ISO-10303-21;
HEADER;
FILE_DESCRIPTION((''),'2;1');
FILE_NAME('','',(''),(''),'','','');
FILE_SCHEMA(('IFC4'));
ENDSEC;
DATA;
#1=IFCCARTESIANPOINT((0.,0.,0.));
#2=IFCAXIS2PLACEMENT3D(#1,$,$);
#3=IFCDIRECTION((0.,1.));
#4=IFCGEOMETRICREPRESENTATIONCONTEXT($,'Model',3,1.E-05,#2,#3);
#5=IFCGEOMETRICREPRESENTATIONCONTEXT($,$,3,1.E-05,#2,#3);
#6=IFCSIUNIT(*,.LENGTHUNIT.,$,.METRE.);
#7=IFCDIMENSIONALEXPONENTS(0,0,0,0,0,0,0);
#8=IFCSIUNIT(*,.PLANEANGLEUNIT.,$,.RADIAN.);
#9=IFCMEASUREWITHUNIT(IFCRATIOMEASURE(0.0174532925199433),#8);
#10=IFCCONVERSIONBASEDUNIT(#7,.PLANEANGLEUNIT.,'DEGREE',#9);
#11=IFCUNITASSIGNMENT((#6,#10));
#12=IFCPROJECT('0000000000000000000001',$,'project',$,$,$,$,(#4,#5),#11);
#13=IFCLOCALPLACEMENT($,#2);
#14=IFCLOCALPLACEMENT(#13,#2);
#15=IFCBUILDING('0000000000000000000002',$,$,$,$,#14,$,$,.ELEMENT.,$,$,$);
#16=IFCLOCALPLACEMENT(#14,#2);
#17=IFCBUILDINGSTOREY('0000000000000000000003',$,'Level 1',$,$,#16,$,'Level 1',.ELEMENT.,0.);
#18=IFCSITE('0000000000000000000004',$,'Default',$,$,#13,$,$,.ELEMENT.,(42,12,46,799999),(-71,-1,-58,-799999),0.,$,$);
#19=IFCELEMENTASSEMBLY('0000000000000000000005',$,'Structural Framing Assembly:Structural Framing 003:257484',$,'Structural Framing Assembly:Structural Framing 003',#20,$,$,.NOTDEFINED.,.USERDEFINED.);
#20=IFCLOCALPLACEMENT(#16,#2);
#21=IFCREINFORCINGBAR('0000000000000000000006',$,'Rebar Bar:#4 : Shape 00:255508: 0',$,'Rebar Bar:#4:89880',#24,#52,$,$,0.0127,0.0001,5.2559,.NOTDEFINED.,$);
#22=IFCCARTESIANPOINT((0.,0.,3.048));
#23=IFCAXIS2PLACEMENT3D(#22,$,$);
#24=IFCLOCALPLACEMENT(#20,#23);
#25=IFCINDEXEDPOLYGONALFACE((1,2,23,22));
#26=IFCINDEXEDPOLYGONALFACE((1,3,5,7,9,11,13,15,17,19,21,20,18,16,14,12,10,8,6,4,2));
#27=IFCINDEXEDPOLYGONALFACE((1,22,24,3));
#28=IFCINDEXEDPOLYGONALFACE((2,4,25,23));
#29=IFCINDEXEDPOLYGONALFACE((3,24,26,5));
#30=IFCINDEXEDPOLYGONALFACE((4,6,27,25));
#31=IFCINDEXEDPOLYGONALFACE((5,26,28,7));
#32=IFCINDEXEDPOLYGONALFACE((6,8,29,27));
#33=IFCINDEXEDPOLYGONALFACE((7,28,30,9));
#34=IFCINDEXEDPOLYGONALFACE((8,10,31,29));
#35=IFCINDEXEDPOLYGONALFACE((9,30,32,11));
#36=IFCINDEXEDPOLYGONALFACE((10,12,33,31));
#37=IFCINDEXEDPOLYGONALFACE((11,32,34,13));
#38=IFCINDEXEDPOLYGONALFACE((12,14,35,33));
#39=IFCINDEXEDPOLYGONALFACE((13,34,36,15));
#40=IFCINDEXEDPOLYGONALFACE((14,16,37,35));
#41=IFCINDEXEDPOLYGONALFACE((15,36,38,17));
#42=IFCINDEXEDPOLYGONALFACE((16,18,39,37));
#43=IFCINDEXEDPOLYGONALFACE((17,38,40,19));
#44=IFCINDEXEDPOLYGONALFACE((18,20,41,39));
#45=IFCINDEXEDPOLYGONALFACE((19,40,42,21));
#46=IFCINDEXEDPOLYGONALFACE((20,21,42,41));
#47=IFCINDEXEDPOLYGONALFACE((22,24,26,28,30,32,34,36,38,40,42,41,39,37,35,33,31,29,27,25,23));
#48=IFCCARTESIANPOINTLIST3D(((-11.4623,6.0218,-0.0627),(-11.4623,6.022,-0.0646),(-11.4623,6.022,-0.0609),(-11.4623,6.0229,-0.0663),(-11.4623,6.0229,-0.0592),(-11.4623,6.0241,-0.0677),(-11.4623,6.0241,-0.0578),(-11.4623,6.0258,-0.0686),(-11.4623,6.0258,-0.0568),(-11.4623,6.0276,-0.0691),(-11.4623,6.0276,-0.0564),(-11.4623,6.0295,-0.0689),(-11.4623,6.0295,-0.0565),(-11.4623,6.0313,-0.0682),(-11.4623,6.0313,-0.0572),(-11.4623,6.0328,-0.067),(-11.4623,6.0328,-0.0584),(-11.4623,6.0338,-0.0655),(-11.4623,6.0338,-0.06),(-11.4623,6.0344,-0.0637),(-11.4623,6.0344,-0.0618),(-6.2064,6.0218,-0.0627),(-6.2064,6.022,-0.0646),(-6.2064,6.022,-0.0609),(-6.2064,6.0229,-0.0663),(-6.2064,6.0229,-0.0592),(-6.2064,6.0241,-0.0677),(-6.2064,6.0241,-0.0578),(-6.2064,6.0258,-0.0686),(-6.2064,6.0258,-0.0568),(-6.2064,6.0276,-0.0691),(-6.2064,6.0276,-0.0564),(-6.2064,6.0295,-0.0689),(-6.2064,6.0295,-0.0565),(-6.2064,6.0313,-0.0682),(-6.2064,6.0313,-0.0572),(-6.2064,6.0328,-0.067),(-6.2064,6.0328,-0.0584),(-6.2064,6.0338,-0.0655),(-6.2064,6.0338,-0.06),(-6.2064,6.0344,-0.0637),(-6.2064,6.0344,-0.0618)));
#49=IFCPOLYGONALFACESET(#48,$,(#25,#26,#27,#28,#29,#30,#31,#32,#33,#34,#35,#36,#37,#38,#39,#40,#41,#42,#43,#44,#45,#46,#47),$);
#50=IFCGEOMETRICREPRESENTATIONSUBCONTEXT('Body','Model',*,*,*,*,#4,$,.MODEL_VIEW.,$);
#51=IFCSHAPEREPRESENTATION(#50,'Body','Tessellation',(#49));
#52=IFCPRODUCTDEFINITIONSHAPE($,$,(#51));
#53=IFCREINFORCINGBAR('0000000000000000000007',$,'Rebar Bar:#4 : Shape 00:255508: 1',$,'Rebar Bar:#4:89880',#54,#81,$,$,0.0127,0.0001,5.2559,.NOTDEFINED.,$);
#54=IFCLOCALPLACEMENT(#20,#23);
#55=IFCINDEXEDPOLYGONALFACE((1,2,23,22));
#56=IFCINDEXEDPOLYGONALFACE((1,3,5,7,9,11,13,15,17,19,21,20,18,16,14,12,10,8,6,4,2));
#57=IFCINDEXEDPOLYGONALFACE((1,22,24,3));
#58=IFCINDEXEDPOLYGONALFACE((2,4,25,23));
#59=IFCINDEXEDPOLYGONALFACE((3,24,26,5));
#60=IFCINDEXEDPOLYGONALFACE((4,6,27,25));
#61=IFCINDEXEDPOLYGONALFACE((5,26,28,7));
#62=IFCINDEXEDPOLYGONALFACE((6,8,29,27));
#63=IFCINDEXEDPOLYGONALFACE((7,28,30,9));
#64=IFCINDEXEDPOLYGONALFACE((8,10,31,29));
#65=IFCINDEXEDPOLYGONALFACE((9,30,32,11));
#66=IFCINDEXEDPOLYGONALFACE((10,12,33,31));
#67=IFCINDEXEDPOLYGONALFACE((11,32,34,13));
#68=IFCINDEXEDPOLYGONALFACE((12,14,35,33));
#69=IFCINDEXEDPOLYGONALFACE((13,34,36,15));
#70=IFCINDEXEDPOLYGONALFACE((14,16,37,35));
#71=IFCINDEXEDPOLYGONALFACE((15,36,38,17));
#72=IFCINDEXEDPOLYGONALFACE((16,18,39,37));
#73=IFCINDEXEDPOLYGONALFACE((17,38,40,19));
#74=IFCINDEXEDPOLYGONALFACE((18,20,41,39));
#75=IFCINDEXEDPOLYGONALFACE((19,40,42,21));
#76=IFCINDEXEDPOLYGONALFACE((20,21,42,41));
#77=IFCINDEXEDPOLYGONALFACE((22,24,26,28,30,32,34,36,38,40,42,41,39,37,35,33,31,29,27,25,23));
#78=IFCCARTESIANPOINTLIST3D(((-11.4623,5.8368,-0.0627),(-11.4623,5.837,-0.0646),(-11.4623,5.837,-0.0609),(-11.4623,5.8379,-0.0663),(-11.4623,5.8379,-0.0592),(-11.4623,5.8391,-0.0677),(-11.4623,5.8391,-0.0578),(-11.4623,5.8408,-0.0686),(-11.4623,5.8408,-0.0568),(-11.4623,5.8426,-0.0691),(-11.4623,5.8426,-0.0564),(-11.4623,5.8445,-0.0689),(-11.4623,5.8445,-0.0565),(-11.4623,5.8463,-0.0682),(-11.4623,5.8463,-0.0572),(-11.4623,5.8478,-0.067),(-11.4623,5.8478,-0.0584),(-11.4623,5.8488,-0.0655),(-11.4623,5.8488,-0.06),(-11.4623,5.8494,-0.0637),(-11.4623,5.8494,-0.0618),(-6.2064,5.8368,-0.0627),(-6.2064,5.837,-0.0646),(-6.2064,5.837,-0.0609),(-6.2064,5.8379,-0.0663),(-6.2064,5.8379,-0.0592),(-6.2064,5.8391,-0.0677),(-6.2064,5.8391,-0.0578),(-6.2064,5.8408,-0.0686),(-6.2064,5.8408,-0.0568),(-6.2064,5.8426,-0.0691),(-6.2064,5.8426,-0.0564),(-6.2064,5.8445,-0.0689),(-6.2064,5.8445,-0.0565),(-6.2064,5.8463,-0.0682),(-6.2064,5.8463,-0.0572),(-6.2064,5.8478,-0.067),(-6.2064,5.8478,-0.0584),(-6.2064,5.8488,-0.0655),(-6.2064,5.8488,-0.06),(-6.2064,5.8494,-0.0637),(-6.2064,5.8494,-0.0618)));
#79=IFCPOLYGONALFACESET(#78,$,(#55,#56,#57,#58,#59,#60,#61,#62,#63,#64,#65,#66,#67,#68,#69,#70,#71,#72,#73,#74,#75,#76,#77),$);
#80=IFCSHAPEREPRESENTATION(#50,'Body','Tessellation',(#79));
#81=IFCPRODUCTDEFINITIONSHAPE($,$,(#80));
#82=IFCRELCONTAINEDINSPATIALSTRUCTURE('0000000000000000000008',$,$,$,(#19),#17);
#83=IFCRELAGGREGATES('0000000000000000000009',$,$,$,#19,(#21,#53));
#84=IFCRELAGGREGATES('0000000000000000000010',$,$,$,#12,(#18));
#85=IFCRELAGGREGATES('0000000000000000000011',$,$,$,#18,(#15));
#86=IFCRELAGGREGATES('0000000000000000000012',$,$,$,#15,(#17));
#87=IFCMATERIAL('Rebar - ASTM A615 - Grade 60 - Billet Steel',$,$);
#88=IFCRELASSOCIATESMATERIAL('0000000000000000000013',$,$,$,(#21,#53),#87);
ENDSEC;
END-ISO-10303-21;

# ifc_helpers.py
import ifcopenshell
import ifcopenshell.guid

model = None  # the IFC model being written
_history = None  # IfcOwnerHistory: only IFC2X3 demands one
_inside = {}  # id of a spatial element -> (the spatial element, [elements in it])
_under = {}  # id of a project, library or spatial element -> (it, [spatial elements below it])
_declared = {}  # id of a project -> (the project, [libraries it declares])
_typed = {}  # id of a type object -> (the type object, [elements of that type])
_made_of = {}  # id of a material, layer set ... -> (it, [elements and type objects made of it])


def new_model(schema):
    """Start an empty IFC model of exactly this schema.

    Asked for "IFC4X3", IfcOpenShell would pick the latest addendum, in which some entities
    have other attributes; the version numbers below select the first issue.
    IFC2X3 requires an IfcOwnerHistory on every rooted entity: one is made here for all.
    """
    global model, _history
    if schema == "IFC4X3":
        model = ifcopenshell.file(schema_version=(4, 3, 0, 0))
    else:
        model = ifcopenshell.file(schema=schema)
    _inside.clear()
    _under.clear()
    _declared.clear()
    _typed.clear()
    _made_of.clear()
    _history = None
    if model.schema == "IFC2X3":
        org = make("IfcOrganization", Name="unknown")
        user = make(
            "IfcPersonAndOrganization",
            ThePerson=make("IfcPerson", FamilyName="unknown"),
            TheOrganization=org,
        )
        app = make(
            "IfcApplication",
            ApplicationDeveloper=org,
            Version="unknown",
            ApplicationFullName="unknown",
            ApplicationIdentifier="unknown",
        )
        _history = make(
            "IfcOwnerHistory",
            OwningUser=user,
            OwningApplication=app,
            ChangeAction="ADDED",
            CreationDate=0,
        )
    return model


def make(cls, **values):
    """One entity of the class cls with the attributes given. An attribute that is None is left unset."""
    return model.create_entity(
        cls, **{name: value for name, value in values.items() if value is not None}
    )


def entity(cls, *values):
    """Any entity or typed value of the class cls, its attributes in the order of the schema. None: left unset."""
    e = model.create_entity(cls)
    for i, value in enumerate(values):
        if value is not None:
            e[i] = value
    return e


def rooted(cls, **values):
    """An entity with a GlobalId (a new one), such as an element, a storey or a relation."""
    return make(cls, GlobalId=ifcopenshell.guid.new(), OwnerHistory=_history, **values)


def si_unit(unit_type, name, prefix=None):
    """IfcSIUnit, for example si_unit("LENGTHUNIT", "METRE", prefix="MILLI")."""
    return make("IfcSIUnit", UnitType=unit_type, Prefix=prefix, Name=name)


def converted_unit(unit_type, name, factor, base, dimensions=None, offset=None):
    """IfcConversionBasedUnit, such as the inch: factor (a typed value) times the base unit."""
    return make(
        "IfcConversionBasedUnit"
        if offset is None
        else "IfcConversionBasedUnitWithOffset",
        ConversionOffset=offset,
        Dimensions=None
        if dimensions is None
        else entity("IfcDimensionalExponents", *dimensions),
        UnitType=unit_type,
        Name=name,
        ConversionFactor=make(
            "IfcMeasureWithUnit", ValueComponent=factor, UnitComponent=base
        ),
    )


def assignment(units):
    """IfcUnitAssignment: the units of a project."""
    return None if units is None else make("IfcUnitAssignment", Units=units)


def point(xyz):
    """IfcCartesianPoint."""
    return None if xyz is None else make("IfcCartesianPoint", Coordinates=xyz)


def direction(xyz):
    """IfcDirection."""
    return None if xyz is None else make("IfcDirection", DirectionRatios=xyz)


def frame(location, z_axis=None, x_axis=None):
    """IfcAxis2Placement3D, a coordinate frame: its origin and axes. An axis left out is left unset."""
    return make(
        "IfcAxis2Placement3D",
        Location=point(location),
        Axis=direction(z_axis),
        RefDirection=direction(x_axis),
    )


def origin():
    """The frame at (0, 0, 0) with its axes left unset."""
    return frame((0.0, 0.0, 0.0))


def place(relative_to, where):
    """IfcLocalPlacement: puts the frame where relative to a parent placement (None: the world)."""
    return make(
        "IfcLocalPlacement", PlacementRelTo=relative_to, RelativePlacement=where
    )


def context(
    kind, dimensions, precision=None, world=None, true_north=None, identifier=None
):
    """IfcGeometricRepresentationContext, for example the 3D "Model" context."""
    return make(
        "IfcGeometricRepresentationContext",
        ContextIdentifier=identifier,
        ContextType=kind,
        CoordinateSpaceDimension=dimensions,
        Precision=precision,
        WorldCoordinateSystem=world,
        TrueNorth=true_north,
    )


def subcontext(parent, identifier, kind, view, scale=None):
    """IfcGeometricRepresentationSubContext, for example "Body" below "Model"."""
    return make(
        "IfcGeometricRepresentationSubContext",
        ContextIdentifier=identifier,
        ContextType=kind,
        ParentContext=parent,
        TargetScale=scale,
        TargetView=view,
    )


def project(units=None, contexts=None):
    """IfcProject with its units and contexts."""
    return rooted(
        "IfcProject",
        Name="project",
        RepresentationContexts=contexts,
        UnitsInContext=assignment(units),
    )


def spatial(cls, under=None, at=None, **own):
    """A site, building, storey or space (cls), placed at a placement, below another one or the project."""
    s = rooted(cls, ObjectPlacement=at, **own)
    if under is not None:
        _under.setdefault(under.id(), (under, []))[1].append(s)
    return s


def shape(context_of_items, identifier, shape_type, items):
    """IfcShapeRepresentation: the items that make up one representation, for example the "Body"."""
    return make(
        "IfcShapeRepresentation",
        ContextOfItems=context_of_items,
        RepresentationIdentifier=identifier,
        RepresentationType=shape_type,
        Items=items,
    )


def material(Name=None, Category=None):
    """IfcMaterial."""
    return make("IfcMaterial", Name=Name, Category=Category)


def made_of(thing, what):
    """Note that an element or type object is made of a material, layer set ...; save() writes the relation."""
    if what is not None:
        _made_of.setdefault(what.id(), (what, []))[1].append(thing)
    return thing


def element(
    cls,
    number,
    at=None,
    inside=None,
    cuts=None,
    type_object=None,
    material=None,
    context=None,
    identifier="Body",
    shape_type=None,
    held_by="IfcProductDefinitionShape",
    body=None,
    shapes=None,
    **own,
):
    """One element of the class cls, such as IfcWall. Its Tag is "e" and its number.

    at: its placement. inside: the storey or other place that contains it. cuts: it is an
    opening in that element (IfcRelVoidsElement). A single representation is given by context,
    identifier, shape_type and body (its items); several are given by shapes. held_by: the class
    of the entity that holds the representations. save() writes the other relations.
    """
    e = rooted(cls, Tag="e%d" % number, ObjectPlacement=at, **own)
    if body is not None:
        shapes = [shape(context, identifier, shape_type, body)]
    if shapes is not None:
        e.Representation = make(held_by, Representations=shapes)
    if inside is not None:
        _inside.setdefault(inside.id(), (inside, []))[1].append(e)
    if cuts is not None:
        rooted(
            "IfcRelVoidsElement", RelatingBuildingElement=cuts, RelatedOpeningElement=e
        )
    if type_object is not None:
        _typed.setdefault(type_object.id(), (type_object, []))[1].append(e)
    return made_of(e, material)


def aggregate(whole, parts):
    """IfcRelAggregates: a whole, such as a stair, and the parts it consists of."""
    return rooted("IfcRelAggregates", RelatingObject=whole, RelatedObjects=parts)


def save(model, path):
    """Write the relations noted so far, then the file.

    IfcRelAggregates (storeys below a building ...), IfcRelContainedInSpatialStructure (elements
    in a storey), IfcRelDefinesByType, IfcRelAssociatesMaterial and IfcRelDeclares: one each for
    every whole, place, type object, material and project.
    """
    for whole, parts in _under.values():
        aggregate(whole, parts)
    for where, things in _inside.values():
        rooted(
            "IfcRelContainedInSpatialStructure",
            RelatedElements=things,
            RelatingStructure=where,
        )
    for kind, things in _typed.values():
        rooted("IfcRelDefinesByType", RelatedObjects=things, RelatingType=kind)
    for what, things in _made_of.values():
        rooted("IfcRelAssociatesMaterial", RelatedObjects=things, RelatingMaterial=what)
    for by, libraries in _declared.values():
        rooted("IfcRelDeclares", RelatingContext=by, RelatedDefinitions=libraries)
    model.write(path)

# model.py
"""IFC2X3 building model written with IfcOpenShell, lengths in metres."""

from ifc_helpers import new_model, entity, si_unit, converted_unit, direction, frame, origin, place, context, subcontext, project, spatial, material, element, aggregate, save


model = new_model("IFC2X3")

# Units and contexts
model_context = context("Model", 3, precision=1e-05, world=origin(), true_north=direction((0.0, 1.0)))
context_of_model = context(None, 3, precision=1e-05, world=origin(), true_north=direction((0.0, 1.0)))
body_context = subcontext(model_context, "Body", "Model", "MODEL_VIEW")
ifc_project = project(units=[si_unit("LENGTHUNIT", "METRE"), converted_unit("PLANEANGLEUNIT", "DEGREE", entity("IfcRatioMeasure", 0.0174532925199433), si_unit("PLANEANGLEUNIT", "RADIAN"), dimensions=[0, 0, 0, 0, 0, 0, 0])], contexts=[model_context, context_of_model])

# Site, building, storey
site_placement = place(None, origin())
site = spatial("IfcSite", under=ifc_project, at=site_placement, Name="Default", CompositionType="ELEMENT", RefLatitude=(42, 12, 46, 799999), RefLongitude=(-71, -1, -58, -799999), RefElevation=0.0)
building_placement = place(site_placement, origin())
building = spatial("IfcBuilding", under=site, at=building_placement, CompositionType="ELEMENT")
storey_placement = place(building_placement, origin())
storey = spatial("IfcBuildingStorey", under=building, at=storey_placement, Name="Level 1", LongName="Level 1", CompositionType="ELEMENT", Elevation=0.0)

# Element assembly, reinforcing bars
ifc_material_1 = material(Name="Rebar - ASTM A615 - Grade 60 - Billet Steel")
assembly_1_placement = place(storey_placement, origin())
assembly_1 = element("IfcElementAssembly", 1, at=assembly_1_placement, inside=storey, Name="Structural Framing Assembly:Structural Framing 003:257484", ObjectType="Structural Framing Assembly:Structural Framing 003", AssemblyPlace="NOTDEFINED", PredefinedType="USERDEFINED")
reinforcing_bar_1_placement = place(assembly_1_placement, frame((0.0, 0.0, 3.048)))
reinforcing_bar_1 = element("IfcReinforcingBar", 2, at=reinforcing_bar_1_placement, material=ifc_material_1, Name="Rebar Bar:#4 : Shape 00:255508: 0", ObjectType="Rebar Bar:#4:89880", BarLength=5.2559, BarRole="NOTDEFINED", CrossSectionArea=0.0001, NominalDiameter=0.0127, context=body_context, shape_type="AdvancedSweptSolid", body=[
    entity("IfcSweptDiskSolid", entity("IfcCompositeCurve", [entity("IfcCompositeCurveSegment", "CONTINUOUS", True, entity("IfcPolyline", [entity("IfcCartesianPoint", [-6.2064, 6.0281, -0.0627]), entity("IfcCartesianPoint", [-11.4623, 6.0281, -0.0627])]))], False), 0.0063, None, 0.0, 1.0),
])
reinforcing_bar_2_placement = place(assembly_1_placement, frame((0.0, 0.0, 3.048)))
reinforcing_bar_2 = element("IfcReinforcingBar", 3, at=reinforcing_bar_2_placement, material=ifc_material_1, Name="Rebar Bar:#4 : Shape 00:255508: 1", ObjectType="Rebar Bar:#4:89880", BarLength=5.2559, BarRole="NOTDEFINED", CrossSectionArea=0.0001, NominalDiameter=0.0127, context=body_context, shape_type="AdvancedSweptSolid", body=[
    entity("IfcSweptDiskSolid", entity("IfcCompositeCurve", [entity("IfcCompositeCurveSegment", "CONTINUOUS", True, entity("IfcPolyline", [entity("IfcCartesianPoint", [-6.2064, 5.8431, -0.0627]), entity("IfcCartesianPoint", [-11.4623, 5.8431, -0.0627])]))], False), 0.0063, None, 0.0, 1.0),
])
aggregate(assembly_1, [reinforcing_bar_1, reinforcing_bar_2])

save(model, "model.ifc")
